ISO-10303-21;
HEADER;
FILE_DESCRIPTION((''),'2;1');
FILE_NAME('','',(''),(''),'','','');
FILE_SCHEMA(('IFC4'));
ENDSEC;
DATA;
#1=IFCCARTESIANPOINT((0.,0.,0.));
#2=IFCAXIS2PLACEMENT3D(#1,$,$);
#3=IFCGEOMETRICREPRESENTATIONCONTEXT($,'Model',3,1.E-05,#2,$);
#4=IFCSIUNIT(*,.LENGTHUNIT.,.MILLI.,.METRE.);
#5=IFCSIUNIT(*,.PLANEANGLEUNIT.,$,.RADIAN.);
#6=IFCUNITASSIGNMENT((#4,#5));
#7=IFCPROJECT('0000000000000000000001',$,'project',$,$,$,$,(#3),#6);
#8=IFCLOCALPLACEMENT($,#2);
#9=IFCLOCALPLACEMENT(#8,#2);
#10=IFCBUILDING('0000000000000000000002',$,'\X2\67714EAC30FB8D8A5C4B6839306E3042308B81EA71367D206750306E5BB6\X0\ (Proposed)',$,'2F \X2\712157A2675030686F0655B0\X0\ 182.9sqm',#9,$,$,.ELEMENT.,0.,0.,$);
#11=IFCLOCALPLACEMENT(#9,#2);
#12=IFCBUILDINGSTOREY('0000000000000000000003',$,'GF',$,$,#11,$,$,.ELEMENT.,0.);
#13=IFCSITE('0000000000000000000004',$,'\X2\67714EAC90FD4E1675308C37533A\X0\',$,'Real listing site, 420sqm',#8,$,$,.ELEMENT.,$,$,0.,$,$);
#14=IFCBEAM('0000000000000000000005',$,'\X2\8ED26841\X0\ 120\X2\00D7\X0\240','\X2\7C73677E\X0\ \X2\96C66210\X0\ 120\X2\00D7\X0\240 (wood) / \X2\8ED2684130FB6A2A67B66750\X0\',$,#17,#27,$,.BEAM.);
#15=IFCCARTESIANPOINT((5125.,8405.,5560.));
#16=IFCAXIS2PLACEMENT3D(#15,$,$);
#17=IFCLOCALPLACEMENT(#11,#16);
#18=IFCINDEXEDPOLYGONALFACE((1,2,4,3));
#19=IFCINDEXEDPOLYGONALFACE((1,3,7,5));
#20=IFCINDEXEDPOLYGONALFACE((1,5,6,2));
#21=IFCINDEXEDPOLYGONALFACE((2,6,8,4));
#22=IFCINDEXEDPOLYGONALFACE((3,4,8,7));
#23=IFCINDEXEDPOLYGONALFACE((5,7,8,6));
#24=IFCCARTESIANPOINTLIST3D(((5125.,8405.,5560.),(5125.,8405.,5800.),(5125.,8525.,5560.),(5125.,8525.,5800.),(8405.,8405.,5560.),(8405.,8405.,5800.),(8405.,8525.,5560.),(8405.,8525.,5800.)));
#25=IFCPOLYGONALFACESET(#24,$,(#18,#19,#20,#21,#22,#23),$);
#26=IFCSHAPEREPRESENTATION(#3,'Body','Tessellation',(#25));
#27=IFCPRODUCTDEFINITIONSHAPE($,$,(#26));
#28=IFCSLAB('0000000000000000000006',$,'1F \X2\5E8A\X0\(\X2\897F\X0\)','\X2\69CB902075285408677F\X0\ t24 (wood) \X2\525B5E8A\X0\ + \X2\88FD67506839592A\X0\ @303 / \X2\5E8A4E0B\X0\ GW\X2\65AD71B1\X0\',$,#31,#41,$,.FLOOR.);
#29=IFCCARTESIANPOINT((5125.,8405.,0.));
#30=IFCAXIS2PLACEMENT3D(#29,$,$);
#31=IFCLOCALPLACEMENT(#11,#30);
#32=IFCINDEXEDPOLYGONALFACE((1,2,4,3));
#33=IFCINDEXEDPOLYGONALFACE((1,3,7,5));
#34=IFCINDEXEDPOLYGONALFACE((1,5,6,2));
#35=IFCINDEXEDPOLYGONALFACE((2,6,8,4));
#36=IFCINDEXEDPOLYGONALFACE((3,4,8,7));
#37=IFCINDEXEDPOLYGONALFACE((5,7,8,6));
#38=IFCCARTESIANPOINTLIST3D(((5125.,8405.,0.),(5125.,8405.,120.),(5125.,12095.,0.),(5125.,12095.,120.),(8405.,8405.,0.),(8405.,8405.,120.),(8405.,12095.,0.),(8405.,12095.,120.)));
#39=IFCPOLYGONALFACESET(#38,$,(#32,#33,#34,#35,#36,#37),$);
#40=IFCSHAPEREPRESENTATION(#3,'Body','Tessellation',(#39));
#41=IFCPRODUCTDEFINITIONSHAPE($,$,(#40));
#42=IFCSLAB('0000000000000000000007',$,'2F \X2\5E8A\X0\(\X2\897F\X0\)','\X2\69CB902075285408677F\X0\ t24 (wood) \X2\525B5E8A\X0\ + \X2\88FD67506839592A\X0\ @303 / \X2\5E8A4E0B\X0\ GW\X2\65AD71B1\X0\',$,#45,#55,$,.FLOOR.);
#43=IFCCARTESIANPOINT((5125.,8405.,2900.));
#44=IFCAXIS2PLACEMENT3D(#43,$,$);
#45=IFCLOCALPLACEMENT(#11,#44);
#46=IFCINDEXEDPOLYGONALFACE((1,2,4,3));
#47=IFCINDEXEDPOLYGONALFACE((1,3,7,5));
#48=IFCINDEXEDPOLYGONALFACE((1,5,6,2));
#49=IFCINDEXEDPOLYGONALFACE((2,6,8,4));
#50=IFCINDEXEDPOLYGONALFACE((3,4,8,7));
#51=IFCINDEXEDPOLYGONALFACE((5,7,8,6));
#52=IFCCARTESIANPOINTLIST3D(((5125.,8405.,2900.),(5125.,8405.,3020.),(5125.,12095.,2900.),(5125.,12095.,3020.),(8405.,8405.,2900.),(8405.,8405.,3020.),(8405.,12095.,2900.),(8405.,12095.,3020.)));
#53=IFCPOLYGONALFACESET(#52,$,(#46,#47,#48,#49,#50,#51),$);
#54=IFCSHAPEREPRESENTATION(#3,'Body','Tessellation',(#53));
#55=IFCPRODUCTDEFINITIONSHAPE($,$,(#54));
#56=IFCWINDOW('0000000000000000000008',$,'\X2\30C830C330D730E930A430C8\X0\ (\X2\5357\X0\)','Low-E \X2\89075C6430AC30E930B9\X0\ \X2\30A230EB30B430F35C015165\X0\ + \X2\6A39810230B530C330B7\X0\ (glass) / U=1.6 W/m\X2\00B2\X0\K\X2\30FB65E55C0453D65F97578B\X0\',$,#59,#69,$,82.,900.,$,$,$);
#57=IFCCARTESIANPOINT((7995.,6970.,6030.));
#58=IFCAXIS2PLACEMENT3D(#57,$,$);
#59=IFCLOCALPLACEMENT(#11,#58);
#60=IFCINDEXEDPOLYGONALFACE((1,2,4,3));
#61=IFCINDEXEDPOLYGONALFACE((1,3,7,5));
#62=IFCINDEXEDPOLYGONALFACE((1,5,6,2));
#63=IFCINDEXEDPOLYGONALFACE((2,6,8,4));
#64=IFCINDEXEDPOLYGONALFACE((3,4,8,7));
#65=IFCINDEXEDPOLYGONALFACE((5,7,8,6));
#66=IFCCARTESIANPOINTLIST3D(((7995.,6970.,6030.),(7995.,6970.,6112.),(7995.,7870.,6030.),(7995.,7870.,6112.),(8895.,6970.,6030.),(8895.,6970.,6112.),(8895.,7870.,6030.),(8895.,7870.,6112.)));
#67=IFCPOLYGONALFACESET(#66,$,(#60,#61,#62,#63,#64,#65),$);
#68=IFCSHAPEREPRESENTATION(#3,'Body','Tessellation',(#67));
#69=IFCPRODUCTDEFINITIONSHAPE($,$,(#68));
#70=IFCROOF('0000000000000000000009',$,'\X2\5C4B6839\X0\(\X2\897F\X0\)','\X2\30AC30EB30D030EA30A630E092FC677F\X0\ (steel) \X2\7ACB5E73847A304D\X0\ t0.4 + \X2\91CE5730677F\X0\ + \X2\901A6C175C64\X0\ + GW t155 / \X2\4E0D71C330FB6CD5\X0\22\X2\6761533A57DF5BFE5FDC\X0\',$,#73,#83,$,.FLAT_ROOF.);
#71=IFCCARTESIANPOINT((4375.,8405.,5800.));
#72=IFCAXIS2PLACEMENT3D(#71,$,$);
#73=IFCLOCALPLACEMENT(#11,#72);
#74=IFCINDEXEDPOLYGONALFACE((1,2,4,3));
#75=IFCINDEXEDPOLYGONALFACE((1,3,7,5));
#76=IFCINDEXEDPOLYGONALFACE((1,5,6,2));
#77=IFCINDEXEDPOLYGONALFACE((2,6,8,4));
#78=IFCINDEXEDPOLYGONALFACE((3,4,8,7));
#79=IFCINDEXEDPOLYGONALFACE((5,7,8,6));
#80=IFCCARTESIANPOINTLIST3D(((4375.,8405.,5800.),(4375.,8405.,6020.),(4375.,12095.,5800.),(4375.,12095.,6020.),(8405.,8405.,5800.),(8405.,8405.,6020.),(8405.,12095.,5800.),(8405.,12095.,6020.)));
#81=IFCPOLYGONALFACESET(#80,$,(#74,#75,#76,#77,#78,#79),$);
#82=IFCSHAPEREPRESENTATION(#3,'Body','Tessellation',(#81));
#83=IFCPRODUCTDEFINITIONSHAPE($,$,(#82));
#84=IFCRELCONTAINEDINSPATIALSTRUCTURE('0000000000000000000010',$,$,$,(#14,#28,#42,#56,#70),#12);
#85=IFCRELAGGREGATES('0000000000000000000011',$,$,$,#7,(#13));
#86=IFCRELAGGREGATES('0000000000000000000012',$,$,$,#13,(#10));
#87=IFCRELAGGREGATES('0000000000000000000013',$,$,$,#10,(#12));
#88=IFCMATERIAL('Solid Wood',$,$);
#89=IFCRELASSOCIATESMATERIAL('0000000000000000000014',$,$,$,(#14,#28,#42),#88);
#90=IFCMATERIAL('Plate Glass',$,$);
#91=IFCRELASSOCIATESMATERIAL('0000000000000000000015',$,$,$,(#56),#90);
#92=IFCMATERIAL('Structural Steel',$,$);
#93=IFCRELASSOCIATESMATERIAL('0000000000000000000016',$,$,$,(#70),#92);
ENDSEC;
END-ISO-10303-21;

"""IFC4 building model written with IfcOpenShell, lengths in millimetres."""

from ifc_helpers import new_model, si_unit, frame, frame_2d, origin, place, context, project, spatial, rectangle, extrude, material, element, save


model = new_model("IFC4")

# Units and contexts
model_context = context("Model", 3, precision=1e-05, world=origin())
ifc_project = project(units=[si_unit("LENGTHUNIT", "METRE", prefix="MILLI"), si_unit("PLANEANGLEUNIT", "RADIAN")], contexts=[model_context])

# Site, building, storey
site_placement = place(None, origin())
site = spatial("IfcSite", under=ifc_project, at=site_placement, Name="東京都世田谷区", ObjectType="Real listing site, 420sqm", CompositionType="ELEMENT", RefElevation=0.0)
building_placement = place(site_placement, origin())
building = spatial("IfcBuilding", under=site, at=building_placement, Name="東京・越屋根のある自然素材の家 (Proposed)", ObjectType="2F 無垢材と漆喰 182.9sqm", CompositionType="ELEMENT", ElevationOfRefHeight=0.0, ElevationOfTerrain=0.0)
storey_placement = place(building_placement, origin())
storey = spatial("IfcBuildingStorey", under=building, at=storey_placement, Name="GF", CompositionType="ELEMENT", Elevation=0.0)

# Shared definitions
ifc_material_1 = material(Name="Solid Wood")

# Beam
beam_1_placement = place(storey_placement, frame((5125.0, 8405.0, 5560.0)))
element("IfcBeam", 1, at=beam_1_placement, inside=storey, material=ifc_material_1, Name="軒桁 120×240", Description="米松 集成 120×240 (wood) / 軒桁・横架材", PredefinedType="BEAM", context=model_context, shape_type="SweptSolid", body=[
    extrude(rectangle(XDim=3280.0, YDim=120.0, at=frame_2d((1640.0, 60.0))), frame((5125.0, 8405.0, 5560.0)), (0.0, 0.0, 1.0), 240.0),
])

# Slabs
slab_1_placement = place(storey_placement, frame((5125.0, 8405.0, 0.0)))
element("IfcSlab", 2, at=slab_1_placement, inside=storey, material=ifc_material_1, Name="1F 床(西)", Description="構造用合板 t24 (wood) 剛床 + 製材根太 @303 / 床下 GW断熱", PredefinedType="FLOOR", context=model_context, shape_type="SweptSolid", body=[
    extrude(rectangle(XDim=3280.0, YDim=3690.0, at=frame_2d((1640.0, 1845.0))), frame((5125.0, 8405.0, 0.0)), (0.0, 0.0, 1.0), 120.0),
])
slab_2_placement = place(storey_placement, frame((5125.0, 8405.0, 2900.0)))
element("IfcSlab", 3, at=slab_2_placement, inside=storey, material=ifc_material_1, Name="2F 床(西)", Description="構造用合板 t24 (wood) 剛床 + 製材根太 @303 / 床下 GW断熱", PredefinedType="FLOOR", context=model_context, shape_type="SweptSolid", body=[
    extrude(rectangle(XDim=3280.0, YDim=3690.0, at=frame_2d((1640.0, 1845.0))), frame((5125.0, 8405.0, 2900.0)), (0.0, 0.0, 1.0), 120.0),
])

# Window
ifc_material_2 = material(Name="Plate Glass")
window_placement = place(storey_placement, frame((7995.0, 6970.0, 6030.0)))
element("IfcWindow", 4, at=window_placement, inside=storey, material=ifc_material_2, Name="トップライト (南)", Description="Low-E 複層ガラス アルゴン封入 + 樹脂サッシ (glass) / U=1.6 W/m²K・日射取得型", OverallHeight=82.0, OverallWidth=900.0, context=model_context, shape_type="SweptSolid", body=[
    extrude(rectangle(XDim=900.0, YDim=900.0, at=frame_2d((450.0, 450.0))), frame((7995.0, 6970.0, 6030.0)), (0.0, 0.0, 1.0), 82.0),
])

# Roof
ifc_material_3 = material(Name="Structural Steel")
for number, where, name in (
    (5, (4375.0, 8405.0, 5800.0), "屋根(西)"),
):
    element("IfcRoof", number, at=place(storey_placement, frame(where)), inside=storey, material=ifc_material_3, Name=name, Description="ガルバリウム鋼板 (steel) 立平葺き t0.4 + 野地板 + 通気層 + GW t155 / 不燃・法22条区域対応", PredefinedType="FLAT_ROOF", context=model_context, shape_type="SweptSolid", body=[
        extrude(rectangle(XDim=4030.0, YDim=3690.0, at=frame_2d((2015.0, 1845.0))), frame((4375.0, 8405.0, 5800.0)), (0.0, 0.0, 1.0), 220.0),
    ])

save(model, "model.ifc")
